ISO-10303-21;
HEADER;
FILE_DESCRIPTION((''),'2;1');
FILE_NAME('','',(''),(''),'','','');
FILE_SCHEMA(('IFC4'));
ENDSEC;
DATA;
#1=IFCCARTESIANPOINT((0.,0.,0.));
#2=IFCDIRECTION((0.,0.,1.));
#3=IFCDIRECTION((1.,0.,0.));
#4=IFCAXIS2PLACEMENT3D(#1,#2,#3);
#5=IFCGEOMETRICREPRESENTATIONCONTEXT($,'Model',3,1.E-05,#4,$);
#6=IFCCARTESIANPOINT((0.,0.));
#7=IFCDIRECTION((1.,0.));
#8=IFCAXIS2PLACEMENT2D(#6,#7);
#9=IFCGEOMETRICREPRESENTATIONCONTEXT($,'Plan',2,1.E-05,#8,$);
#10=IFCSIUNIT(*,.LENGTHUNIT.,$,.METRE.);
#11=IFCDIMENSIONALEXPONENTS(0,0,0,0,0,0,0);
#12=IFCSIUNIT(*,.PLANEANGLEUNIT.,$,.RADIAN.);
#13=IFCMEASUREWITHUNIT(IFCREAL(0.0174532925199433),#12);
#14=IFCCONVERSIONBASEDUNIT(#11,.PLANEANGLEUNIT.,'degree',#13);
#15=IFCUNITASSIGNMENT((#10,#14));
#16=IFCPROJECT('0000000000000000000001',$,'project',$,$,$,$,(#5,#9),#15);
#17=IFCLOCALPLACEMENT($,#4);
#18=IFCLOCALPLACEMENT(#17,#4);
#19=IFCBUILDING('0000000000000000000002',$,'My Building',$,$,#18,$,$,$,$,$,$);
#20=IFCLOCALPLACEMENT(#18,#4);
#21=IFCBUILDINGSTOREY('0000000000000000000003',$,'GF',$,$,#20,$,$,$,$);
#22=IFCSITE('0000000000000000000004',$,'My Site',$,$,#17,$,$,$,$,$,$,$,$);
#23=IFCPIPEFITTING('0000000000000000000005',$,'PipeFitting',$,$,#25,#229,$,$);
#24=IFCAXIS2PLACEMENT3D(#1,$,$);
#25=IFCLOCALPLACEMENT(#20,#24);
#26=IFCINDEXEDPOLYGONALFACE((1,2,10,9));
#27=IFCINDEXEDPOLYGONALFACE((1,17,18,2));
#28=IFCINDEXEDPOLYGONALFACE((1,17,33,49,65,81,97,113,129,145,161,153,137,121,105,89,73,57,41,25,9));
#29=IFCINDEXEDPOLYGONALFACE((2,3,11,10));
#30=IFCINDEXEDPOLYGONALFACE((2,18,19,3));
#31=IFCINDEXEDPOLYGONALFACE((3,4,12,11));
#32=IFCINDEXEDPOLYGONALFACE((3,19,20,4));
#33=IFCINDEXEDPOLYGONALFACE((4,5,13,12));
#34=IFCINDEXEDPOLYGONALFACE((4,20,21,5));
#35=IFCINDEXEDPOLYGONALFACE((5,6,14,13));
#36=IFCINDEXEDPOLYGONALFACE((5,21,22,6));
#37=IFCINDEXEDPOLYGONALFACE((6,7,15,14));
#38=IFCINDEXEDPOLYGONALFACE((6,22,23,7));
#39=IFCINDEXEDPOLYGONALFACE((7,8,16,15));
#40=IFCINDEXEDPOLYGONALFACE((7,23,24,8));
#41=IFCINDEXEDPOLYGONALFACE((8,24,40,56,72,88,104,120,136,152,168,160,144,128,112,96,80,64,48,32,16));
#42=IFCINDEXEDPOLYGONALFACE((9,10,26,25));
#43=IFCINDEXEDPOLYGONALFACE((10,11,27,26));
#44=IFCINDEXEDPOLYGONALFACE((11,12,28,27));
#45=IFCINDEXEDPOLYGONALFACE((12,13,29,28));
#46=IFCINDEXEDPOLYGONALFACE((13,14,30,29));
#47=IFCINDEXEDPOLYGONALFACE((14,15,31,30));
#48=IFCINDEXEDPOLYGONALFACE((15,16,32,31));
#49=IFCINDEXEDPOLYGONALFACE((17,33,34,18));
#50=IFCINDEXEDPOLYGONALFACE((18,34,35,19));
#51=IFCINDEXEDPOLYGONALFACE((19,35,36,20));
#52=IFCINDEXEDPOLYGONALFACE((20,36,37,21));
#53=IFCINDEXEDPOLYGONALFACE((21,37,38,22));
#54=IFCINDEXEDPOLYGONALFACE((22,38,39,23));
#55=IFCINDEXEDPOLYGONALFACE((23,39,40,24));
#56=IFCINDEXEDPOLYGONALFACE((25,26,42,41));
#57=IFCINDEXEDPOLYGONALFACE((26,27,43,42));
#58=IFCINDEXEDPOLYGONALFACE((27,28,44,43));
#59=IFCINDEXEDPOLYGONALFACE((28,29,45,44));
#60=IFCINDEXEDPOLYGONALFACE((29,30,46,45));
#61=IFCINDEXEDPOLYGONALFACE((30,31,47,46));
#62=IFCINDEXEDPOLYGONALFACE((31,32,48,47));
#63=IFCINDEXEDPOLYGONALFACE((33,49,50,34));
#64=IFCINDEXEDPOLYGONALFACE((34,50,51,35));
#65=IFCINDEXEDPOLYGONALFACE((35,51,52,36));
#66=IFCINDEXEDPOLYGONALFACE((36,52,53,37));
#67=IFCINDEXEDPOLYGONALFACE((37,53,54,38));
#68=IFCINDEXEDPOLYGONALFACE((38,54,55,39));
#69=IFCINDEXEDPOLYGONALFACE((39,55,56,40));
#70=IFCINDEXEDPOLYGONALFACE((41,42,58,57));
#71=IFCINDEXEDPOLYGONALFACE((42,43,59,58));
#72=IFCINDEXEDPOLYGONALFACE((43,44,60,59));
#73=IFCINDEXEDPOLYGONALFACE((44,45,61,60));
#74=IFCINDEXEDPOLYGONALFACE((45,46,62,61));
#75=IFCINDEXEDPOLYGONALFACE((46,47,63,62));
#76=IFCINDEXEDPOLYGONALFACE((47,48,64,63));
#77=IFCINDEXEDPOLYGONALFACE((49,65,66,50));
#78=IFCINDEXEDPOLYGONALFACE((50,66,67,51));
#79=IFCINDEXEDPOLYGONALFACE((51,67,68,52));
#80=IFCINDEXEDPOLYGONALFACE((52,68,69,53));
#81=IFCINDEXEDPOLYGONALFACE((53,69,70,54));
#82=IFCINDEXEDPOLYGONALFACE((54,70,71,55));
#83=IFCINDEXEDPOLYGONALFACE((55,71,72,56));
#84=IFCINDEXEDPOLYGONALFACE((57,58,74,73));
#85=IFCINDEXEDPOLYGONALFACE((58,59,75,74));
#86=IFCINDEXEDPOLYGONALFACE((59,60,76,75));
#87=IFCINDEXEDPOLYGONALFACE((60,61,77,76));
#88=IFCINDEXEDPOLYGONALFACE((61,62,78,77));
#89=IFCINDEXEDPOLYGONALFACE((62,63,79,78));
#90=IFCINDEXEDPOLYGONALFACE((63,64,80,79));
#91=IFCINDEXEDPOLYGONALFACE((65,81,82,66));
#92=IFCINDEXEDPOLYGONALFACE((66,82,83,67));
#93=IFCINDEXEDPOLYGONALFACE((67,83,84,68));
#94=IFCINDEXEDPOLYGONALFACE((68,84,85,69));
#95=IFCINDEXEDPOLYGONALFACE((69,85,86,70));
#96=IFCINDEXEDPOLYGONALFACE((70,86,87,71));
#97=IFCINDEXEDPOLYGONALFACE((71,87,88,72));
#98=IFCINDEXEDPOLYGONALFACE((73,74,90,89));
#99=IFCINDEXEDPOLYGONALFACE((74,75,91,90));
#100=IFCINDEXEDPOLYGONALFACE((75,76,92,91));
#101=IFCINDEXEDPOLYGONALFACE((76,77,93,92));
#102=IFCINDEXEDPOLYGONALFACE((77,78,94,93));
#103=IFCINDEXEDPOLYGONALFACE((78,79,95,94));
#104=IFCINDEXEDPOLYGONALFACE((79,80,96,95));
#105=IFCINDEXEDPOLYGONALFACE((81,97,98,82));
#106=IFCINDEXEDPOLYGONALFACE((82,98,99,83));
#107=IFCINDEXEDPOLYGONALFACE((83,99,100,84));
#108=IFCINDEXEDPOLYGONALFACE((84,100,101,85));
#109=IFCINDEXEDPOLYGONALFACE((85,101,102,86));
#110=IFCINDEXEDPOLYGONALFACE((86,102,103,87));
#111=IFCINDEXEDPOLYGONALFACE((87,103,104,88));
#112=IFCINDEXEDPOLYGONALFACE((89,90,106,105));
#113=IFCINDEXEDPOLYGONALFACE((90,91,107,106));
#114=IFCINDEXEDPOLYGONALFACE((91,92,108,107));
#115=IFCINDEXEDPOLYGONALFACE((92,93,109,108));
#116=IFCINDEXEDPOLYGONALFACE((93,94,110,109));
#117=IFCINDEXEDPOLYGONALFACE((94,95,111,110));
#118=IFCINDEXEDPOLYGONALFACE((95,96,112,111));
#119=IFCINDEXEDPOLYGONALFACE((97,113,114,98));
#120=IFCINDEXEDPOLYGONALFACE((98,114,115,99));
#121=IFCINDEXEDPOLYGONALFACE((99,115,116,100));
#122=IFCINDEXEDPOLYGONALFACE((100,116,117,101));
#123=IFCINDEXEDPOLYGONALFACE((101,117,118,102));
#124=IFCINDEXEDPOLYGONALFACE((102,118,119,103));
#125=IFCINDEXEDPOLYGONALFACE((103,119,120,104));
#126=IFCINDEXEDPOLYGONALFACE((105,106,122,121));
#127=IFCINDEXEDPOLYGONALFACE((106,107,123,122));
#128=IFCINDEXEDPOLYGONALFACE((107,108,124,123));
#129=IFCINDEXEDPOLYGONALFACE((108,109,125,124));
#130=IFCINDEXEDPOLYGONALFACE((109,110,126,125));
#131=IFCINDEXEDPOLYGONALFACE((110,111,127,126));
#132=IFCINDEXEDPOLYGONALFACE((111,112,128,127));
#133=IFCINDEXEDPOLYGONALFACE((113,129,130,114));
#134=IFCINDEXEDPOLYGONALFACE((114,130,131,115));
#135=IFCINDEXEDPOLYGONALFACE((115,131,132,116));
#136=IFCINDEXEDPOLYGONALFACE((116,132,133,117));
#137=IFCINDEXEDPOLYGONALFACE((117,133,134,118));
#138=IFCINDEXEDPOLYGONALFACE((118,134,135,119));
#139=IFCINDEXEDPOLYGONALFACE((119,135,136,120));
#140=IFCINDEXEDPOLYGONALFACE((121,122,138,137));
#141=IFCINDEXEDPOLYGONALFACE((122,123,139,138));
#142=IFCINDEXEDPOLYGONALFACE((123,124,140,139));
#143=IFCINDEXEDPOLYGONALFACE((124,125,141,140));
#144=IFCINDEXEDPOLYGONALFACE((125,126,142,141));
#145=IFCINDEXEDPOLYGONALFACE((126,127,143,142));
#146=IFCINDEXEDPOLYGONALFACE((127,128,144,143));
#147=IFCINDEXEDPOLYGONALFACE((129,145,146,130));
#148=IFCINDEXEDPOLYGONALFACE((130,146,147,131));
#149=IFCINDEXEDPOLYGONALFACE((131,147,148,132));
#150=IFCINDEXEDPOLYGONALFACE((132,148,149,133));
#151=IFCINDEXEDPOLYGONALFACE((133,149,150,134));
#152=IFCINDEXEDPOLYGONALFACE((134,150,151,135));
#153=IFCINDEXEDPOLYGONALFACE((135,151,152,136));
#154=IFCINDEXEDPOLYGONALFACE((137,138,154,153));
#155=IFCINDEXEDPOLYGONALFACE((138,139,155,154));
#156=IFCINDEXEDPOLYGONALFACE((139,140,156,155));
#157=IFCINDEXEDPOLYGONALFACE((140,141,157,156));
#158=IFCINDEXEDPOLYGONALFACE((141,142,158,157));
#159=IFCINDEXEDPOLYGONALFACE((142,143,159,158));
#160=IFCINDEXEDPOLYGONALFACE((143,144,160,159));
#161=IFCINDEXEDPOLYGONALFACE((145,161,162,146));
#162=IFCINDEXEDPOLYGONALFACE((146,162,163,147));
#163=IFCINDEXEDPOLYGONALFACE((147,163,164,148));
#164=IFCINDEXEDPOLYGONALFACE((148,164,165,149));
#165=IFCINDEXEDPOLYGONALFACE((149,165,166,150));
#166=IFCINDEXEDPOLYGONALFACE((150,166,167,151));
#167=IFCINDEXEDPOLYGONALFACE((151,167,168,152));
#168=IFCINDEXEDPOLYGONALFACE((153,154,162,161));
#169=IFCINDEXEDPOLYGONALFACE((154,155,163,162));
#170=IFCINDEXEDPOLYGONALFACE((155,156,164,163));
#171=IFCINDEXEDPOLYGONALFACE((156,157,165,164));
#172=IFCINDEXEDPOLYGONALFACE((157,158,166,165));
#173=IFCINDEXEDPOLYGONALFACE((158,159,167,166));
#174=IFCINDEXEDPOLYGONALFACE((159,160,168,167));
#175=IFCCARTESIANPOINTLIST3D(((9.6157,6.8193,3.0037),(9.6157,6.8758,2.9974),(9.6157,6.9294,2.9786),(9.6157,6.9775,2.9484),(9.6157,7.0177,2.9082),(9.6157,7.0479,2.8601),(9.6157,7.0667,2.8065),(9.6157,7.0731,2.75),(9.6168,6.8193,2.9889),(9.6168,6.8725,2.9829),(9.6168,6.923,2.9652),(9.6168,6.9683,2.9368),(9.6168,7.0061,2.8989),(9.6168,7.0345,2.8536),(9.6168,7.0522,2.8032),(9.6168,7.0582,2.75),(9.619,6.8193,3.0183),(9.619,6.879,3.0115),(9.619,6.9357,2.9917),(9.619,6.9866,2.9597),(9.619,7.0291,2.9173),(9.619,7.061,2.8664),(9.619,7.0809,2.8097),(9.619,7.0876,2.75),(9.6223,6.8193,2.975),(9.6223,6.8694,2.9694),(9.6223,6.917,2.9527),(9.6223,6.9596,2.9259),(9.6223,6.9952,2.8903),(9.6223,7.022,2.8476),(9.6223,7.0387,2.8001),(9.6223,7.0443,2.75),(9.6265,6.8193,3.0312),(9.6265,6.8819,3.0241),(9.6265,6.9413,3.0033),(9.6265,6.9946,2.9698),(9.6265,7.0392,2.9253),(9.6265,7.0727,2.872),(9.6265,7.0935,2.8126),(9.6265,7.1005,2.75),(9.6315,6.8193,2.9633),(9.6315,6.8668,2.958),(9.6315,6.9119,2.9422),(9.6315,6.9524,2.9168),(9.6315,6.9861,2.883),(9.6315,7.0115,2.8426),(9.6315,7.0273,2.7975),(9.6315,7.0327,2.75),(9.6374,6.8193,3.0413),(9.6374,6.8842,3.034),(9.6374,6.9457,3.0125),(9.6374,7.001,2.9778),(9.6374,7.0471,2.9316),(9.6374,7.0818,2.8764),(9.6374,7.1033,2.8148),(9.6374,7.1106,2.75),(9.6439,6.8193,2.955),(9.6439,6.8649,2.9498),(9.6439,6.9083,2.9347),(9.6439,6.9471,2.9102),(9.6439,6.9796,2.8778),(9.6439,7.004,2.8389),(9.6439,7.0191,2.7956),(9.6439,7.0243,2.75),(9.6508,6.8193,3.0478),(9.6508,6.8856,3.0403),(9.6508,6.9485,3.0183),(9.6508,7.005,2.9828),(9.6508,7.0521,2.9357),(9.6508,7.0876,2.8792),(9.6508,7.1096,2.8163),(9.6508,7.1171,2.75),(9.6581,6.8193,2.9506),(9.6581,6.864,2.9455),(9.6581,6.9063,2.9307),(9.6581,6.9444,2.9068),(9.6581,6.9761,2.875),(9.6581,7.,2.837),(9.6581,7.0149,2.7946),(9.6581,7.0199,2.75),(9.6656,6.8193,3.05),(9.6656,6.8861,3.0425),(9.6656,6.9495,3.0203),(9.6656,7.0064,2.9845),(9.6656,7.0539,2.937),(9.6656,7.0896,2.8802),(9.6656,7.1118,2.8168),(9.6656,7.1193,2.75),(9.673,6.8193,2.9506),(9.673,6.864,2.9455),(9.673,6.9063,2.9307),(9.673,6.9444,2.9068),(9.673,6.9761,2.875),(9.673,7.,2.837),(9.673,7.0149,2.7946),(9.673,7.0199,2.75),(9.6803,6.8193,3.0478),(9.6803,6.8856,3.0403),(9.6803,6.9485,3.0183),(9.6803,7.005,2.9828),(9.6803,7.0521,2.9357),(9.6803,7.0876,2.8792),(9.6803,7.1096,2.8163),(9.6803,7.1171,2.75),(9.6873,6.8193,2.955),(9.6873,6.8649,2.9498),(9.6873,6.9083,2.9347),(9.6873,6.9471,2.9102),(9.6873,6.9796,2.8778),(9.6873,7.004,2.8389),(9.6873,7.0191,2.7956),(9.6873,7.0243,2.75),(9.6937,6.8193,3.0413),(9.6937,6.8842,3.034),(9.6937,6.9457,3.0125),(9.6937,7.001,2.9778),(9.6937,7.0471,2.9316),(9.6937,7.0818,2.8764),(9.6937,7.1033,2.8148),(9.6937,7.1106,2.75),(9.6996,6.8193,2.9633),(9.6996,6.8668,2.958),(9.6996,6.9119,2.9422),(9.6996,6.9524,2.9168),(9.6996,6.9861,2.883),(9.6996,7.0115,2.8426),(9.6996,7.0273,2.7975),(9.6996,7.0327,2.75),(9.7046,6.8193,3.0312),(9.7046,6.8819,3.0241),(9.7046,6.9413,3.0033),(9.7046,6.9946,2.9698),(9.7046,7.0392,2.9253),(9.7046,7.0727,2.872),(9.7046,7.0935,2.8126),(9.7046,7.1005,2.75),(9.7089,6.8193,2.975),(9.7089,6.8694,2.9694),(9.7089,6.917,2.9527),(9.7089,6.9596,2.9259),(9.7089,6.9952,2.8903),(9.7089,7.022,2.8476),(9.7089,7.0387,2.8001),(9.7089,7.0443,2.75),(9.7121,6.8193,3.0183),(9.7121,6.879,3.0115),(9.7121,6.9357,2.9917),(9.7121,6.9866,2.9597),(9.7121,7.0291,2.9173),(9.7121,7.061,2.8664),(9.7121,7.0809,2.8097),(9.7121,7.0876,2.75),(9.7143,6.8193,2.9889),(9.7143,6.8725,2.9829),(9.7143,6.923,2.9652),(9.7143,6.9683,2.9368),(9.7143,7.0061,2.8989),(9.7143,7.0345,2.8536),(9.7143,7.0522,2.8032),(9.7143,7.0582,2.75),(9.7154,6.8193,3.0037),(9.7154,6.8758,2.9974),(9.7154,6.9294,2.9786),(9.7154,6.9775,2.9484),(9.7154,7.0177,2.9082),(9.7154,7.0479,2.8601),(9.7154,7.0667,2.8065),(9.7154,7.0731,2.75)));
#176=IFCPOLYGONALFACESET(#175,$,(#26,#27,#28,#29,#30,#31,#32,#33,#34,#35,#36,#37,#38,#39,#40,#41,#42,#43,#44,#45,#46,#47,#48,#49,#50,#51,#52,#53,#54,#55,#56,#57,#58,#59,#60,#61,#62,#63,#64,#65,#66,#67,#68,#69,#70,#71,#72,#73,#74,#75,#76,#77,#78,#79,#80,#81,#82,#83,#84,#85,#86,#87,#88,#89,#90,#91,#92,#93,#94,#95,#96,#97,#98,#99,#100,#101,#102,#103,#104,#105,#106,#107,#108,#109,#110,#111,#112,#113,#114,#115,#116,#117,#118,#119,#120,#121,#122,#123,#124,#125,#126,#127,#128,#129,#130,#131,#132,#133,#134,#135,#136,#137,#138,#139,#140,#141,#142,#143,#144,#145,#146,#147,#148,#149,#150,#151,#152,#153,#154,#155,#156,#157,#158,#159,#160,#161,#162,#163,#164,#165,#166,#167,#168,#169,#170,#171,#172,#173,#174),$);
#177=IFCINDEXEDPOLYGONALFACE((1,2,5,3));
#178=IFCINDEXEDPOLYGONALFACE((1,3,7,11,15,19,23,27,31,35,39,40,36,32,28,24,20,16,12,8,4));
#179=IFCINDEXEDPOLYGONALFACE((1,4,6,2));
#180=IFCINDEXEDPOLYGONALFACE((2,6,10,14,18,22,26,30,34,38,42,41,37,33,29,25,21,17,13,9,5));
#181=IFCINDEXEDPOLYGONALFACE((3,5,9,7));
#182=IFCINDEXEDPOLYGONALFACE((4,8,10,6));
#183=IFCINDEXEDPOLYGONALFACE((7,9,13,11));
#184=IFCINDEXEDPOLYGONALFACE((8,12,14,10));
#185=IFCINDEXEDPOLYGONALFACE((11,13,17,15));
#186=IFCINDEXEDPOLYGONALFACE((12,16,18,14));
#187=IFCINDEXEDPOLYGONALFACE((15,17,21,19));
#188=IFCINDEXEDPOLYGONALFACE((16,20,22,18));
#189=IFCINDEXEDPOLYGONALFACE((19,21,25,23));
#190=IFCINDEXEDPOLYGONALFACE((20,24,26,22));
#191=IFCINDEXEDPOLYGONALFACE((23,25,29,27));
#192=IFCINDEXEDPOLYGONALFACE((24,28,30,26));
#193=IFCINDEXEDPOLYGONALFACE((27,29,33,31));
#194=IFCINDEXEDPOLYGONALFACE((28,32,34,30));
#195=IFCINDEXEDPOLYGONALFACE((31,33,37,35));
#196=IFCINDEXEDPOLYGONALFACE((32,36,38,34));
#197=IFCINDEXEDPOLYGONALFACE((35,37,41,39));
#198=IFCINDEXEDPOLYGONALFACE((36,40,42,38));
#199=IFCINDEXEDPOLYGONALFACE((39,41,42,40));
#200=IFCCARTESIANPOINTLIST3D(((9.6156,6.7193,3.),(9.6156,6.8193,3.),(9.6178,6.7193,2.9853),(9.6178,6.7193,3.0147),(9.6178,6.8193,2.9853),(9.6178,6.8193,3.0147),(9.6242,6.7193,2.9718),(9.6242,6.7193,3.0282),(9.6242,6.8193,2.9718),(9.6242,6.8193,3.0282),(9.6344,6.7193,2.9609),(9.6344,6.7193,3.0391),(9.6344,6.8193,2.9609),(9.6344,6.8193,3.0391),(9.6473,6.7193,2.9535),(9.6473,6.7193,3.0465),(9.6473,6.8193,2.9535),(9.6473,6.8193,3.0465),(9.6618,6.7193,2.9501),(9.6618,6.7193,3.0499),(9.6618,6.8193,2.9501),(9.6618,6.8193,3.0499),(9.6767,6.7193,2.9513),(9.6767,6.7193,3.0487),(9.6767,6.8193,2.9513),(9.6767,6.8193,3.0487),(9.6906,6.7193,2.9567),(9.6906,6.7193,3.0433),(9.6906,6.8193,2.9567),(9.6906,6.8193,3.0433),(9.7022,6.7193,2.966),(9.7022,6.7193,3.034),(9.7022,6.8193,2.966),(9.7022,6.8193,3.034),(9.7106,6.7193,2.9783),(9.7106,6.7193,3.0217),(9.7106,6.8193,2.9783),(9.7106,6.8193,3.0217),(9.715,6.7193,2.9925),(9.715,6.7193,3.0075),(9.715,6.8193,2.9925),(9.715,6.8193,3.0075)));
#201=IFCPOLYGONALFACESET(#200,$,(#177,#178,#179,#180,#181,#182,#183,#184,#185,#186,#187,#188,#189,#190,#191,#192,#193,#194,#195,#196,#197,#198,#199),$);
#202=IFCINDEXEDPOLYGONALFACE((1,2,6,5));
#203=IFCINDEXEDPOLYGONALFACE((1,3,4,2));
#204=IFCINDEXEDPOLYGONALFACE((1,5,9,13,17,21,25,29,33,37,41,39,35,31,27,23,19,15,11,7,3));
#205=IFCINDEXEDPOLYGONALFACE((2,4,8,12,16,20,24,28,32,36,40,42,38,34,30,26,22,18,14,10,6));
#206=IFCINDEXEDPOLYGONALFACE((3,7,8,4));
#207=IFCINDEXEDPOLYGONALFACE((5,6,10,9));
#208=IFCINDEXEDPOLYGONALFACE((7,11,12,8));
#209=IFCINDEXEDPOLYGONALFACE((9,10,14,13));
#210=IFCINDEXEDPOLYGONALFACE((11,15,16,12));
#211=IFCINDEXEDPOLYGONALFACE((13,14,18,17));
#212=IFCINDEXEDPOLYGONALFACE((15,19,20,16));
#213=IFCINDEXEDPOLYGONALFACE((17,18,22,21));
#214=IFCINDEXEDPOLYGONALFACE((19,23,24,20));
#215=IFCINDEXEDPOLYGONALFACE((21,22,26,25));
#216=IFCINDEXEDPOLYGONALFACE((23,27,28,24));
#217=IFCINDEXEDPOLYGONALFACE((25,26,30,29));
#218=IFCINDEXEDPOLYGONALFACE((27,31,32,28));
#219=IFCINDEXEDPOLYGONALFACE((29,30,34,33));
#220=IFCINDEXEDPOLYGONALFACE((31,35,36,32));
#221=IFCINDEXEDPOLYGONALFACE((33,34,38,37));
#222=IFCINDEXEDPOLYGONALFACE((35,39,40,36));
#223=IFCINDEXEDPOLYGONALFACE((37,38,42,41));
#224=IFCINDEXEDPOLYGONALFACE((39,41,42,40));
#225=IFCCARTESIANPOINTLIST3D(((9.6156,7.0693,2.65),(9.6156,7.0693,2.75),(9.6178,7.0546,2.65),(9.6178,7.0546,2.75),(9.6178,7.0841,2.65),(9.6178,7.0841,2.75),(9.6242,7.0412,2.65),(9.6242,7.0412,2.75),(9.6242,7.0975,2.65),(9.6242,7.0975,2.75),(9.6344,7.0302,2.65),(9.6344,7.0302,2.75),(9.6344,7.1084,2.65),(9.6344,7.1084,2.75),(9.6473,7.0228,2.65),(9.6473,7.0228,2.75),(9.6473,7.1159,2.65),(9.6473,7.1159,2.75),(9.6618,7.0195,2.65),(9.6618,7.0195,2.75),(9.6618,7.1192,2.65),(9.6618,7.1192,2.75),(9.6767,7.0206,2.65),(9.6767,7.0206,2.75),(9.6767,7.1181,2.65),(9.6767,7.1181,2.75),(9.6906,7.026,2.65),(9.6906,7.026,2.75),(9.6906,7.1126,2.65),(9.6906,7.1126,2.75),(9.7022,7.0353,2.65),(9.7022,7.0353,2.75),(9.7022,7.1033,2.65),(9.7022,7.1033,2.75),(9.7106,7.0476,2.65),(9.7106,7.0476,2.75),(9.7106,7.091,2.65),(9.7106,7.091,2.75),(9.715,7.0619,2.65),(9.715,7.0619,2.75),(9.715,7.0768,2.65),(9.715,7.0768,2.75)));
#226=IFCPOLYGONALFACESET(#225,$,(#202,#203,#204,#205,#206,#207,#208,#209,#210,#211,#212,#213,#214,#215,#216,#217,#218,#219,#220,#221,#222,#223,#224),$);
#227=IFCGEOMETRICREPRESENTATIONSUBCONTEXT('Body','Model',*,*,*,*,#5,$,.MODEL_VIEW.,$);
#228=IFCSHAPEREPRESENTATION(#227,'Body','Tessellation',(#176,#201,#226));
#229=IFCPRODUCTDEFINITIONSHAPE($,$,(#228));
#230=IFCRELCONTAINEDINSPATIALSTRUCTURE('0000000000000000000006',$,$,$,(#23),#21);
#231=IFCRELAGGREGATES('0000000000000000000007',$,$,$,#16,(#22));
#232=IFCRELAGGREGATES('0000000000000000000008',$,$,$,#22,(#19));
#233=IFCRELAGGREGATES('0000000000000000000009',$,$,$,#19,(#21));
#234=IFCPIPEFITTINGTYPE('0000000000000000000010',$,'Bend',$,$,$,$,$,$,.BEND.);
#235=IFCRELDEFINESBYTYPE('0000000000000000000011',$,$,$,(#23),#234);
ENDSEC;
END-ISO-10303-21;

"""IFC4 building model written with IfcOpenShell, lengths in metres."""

from ifc_helpers import new_model, entity, si_unit, converted_unit, frame, origin_with_axes, origin_2d_with_axis, place, context, subcontext, project, spatial, circle, extrude, source, transform, mapped, type_object, type_shapes, element, save


model = new_model("IFC4")

# Units and contexts
model_context = context("Model", 3, precision=1e-05, world=origin_with_axes())
plan_context = context("Plan", 2, precision=1e-05, world=origin_2d_with_axis())
body_context = subcontext(model_context, "Body", "Model", "MODEL_VIEW")
ifc_project = project(units=[si_unit("LENGTHUNIT", "METRE"), converted_unit("PLANEANGLEUNIT", "degree", entity("IfcReal", 0.0174532925199433), si_unit("PLANEANGLEUNIT", "RADIAN"), dimensions=[0, 0, 0, 0, 0, 0, 0])], contexts=[model_context, plan_context])

# Site, building, storey
site_placement = place(None, origin_with_axes())
site = spatial("IfcSite", under=ifc_project, at=site_placement, Name="My Site")
building_placement = place(site_placement, origin_with_axes())
building = spatial("IfcBuilding", under=site, at=building_placement, Name="My Building")
storey_placement = place(building_placement, origin_with_axes())
storey = spatial("IfcBuildingStorey", under=building, at=storey_placement, Name="GF")

# Pipe fitting
pipe_fitting_type = type_object("IfcPipeFittingType", Name="Bend", PredefinedType="BEND")
shared_shape = source(origin_with_axes(), body_context, "Body", "SolidModel", [
    entity("IfcSweptDiskSolid", entity("IfcIndexedPolyCurve", entity("IfcCartesianPointList3D", [[0.0, 0.0, 0.1], [0.0, -0.0732, 0.2768], [0.0, -0.25, 0.35]]), [entity("IfcArcIndex", [1, 2, 3])]), 0.05),
    extrude(circle(Radius=0.05), origin_with_axes(), (0.0, 0.0, 1.0), 0.1),
    extrude(circle(Radius=0.05), frame((0.0, -0.25, 0.35), z_axis=(0.0, -1.0, 0.0), x_axis=(1.0, 0.0, 0.0)), (0.0, 0.0, 1.0), 0.1),
])
type_shapes(pipe_fitting_type, [shared_shape])
for number, where, z_axis, x_axis, name in (
    (1, (9.6656, 6.7193, 3.0), (0.0, 1.0, 0.0), (-1.0, 0.0, 0.0), "PipeFitting"),
):
    element("IfcPipeFitting", number, at=place(storey_placement, frame(where, z_axis=z_axis, x_axis=x_axis)), inside=storey, type_object=pipe_fitting_type, Name=name, context=body_context, shape_type="MappedRepresentation", body=[
        mapped(shared_shape, transform((0.0, 0.0, 0.0), x_axis=(1.0, 0.0, 0.0), y_axis=(0.0, 1.0, 0.0), z_axis=(0.0, 0.0, 1.0), scale=1.0)),
    ])

save(model, "model.ifc")
